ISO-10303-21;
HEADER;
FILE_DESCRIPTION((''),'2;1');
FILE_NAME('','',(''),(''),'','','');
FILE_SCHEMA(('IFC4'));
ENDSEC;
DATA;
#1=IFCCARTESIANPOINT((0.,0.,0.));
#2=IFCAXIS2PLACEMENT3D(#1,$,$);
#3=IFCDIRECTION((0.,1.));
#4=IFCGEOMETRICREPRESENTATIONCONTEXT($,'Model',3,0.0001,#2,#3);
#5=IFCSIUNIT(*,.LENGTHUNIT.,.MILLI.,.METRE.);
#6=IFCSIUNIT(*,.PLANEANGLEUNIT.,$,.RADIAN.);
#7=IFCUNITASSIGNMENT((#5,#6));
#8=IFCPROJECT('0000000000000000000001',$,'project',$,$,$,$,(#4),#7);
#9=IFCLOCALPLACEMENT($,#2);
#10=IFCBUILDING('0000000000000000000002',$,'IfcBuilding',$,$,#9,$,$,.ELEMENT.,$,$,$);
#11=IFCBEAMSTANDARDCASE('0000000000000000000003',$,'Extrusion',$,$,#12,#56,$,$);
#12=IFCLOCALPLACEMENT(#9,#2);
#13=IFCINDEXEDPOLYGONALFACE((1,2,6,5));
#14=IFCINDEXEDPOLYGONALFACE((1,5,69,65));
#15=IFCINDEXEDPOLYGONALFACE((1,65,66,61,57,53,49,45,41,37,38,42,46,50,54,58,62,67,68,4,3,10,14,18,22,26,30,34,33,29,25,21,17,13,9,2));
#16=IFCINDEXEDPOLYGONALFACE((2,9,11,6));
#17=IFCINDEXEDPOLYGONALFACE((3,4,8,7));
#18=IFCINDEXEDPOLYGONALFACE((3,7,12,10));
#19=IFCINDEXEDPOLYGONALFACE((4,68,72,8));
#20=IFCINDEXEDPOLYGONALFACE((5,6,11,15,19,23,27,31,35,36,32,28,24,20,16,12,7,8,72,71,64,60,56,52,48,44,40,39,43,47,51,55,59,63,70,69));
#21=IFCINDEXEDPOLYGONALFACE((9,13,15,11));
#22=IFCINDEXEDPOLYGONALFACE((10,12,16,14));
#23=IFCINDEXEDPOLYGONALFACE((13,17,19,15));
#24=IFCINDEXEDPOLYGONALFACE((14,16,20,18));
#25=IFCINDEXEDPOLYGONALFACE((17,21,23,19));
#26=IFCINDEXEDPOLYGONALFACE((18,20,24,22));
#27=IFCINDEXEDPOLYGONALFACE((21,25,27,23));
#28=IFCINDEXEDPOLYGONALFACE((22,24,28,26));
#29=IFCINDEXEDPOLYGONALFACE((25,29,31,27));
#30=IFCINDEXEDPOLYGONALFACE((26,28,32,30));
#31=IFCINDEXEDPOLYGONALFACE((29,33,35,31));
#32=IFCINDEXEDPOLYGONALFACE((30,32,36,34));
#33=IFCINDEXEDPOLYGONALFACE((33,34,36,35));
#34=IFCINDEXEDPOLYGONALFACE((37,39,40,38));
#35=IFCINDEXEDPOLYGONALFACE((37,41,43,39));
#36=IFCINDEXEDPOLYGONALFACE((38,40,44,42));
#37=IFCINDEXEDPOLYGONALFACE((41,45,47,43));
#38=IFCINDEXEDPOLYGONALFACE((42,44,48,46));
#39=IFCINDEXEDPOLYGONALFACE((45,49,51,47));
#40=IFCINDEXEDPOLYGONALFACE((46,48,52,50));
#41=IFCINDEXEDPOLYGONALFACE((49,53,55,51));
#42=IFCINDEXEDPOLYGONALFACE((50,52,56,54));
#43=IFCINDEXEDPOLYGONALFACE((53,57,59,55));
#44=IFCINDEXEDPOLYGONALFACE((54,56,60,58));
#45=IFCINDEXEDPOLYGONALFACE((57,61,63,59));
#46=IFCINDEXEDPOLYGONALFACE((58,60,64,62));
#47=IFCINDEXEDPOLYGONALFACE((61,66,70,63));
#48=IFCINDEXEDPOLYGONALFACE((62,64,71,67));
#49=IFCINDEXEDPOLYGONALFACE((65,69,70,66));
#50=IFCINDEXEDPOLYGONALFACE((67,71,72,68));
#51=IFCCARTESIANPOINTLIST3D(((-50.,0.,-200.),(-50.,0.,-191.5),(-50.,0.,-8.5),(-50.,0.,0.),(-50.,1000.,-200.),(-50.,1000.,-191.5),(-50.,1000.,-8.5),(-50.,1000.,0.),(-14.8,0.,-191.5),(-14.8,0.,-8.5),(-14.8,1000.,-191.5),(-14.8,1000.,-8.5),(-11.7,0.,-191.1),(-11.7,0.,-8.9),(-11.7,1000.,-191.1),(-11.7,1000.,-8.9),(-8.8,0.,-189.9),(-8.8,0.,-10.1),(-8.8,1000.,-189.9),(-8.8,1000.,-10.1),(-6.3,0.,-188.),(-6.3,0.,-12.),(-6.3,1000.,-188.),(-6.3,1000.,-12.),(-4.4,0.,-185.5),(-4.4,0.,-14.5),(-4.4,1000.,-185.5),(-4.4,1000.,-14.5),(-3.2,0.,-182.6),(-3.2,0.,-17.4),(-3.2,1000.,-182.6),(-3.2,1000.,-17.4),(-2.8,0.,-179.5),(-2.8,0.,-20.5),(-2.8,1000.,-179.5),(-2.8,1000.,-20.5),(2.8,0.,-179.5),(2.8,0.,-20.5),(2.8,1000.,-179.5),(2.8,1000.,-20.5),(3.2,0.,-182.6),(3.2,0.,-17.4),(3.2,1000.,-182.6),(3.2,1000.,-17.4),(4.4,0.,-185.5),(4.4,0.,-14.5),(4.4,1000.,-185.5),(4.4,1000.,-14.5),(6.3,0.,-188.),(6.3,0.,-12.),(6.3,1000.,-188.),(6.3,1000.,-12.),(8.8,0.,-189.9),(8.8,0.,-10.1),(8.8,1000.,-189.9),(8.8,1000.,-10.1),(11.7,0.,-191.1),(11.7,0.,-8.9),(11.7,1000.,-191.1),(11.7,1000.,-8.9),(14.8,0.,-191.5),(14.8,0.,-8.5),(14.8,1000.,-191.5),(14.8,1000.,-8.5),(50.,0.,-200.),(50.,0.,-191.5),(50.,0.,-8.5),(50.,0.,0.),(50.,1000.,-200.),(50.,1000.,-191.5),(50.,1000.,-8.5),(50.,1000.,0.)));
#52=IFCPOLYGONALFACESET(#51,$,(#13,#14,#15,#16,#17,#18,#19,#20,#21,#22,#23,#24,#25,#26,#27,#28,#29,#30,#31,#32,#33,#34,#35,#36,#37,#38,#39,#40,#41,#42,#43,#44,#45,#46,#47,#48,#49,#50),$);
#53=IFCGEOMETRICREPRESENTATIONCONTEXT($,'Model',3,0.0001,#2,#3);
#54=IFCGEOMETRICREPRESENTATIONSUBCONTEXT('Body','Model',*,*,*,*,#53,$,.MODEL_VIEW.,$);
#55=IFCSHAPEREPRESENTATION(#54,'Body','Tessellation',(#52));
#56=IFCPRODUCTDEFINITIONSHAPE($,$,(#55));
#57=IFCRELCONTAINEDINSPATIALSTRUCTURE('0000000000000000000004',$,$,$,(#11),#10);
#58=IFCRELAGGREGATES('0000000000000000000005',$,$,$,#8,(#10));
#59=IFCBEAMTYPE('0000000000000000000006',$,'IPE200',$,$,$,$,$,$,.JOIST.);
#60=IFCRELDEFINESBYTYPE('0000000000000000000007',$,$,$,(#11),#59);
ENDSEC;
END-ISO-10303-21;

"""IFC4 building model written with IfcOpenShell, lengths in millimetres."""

from ifc_helpers import new_model, si_unit, direction, frame, origin, place, context, subcontext, project, spatial, i_section, extrude, type_object, element, save


model = new_model("IFC4")

# Units and contexts
model_context_1 = context("Model", 3, precision=0.0001, world=origin(), true_north=direction((0.0, 1.0)))
model_context_2 = context("Model", 3, precision=0.0001, world=origin(), true_north=direction((0.0, 1.0)))
body_context = subcontext(model_context_1, "Body", "Model", "MODEL_VIEW")
ifc_project = project(units=[si_unit("LENGTHUNIT", "METRE", prefix="MILLI"), si_unit("PLANEANGLEUNIT", "RADIAN")], contexts=[model_context_2])

# Building
building_placement = place(None, origin())
building = spatial("IfcBuilding", under=ifc_project, at=building_placement, Name="IfcBuilding", CompositionType="ELEMENT")

# Beam
beam_type = type_object("IfcBeamType", Name="IPE200", PredefinedType="JOIST")
beam_1_placement = place(None, frame((0.0, 0.0, 0.0), z_axis=(0.0, 1.0, 0.0), x_axis=(-1.0, 0.0, 0.0)))
element("IfcBeamStandardCase", 1, at=beam_1_placement, inside=building, type_object=beam_type, Name="Extrusion", context=body_context, shape_type="SweptSolid", body=[
    extrude(i_section(OverallWidth=100.0, OverallDepth=200.0, WebThickness=5.6, FlangeThickness=8.5, FilletRadius=12.0), frame((0.0, -100.0, 0.0), z_axis=(0.0, 0.0, 1.0), x_axis=(1.0, 0.0, 0.0)), (0.0, 0.0, 1.0), 1000.0),
])

save(model, "model.ifc")
